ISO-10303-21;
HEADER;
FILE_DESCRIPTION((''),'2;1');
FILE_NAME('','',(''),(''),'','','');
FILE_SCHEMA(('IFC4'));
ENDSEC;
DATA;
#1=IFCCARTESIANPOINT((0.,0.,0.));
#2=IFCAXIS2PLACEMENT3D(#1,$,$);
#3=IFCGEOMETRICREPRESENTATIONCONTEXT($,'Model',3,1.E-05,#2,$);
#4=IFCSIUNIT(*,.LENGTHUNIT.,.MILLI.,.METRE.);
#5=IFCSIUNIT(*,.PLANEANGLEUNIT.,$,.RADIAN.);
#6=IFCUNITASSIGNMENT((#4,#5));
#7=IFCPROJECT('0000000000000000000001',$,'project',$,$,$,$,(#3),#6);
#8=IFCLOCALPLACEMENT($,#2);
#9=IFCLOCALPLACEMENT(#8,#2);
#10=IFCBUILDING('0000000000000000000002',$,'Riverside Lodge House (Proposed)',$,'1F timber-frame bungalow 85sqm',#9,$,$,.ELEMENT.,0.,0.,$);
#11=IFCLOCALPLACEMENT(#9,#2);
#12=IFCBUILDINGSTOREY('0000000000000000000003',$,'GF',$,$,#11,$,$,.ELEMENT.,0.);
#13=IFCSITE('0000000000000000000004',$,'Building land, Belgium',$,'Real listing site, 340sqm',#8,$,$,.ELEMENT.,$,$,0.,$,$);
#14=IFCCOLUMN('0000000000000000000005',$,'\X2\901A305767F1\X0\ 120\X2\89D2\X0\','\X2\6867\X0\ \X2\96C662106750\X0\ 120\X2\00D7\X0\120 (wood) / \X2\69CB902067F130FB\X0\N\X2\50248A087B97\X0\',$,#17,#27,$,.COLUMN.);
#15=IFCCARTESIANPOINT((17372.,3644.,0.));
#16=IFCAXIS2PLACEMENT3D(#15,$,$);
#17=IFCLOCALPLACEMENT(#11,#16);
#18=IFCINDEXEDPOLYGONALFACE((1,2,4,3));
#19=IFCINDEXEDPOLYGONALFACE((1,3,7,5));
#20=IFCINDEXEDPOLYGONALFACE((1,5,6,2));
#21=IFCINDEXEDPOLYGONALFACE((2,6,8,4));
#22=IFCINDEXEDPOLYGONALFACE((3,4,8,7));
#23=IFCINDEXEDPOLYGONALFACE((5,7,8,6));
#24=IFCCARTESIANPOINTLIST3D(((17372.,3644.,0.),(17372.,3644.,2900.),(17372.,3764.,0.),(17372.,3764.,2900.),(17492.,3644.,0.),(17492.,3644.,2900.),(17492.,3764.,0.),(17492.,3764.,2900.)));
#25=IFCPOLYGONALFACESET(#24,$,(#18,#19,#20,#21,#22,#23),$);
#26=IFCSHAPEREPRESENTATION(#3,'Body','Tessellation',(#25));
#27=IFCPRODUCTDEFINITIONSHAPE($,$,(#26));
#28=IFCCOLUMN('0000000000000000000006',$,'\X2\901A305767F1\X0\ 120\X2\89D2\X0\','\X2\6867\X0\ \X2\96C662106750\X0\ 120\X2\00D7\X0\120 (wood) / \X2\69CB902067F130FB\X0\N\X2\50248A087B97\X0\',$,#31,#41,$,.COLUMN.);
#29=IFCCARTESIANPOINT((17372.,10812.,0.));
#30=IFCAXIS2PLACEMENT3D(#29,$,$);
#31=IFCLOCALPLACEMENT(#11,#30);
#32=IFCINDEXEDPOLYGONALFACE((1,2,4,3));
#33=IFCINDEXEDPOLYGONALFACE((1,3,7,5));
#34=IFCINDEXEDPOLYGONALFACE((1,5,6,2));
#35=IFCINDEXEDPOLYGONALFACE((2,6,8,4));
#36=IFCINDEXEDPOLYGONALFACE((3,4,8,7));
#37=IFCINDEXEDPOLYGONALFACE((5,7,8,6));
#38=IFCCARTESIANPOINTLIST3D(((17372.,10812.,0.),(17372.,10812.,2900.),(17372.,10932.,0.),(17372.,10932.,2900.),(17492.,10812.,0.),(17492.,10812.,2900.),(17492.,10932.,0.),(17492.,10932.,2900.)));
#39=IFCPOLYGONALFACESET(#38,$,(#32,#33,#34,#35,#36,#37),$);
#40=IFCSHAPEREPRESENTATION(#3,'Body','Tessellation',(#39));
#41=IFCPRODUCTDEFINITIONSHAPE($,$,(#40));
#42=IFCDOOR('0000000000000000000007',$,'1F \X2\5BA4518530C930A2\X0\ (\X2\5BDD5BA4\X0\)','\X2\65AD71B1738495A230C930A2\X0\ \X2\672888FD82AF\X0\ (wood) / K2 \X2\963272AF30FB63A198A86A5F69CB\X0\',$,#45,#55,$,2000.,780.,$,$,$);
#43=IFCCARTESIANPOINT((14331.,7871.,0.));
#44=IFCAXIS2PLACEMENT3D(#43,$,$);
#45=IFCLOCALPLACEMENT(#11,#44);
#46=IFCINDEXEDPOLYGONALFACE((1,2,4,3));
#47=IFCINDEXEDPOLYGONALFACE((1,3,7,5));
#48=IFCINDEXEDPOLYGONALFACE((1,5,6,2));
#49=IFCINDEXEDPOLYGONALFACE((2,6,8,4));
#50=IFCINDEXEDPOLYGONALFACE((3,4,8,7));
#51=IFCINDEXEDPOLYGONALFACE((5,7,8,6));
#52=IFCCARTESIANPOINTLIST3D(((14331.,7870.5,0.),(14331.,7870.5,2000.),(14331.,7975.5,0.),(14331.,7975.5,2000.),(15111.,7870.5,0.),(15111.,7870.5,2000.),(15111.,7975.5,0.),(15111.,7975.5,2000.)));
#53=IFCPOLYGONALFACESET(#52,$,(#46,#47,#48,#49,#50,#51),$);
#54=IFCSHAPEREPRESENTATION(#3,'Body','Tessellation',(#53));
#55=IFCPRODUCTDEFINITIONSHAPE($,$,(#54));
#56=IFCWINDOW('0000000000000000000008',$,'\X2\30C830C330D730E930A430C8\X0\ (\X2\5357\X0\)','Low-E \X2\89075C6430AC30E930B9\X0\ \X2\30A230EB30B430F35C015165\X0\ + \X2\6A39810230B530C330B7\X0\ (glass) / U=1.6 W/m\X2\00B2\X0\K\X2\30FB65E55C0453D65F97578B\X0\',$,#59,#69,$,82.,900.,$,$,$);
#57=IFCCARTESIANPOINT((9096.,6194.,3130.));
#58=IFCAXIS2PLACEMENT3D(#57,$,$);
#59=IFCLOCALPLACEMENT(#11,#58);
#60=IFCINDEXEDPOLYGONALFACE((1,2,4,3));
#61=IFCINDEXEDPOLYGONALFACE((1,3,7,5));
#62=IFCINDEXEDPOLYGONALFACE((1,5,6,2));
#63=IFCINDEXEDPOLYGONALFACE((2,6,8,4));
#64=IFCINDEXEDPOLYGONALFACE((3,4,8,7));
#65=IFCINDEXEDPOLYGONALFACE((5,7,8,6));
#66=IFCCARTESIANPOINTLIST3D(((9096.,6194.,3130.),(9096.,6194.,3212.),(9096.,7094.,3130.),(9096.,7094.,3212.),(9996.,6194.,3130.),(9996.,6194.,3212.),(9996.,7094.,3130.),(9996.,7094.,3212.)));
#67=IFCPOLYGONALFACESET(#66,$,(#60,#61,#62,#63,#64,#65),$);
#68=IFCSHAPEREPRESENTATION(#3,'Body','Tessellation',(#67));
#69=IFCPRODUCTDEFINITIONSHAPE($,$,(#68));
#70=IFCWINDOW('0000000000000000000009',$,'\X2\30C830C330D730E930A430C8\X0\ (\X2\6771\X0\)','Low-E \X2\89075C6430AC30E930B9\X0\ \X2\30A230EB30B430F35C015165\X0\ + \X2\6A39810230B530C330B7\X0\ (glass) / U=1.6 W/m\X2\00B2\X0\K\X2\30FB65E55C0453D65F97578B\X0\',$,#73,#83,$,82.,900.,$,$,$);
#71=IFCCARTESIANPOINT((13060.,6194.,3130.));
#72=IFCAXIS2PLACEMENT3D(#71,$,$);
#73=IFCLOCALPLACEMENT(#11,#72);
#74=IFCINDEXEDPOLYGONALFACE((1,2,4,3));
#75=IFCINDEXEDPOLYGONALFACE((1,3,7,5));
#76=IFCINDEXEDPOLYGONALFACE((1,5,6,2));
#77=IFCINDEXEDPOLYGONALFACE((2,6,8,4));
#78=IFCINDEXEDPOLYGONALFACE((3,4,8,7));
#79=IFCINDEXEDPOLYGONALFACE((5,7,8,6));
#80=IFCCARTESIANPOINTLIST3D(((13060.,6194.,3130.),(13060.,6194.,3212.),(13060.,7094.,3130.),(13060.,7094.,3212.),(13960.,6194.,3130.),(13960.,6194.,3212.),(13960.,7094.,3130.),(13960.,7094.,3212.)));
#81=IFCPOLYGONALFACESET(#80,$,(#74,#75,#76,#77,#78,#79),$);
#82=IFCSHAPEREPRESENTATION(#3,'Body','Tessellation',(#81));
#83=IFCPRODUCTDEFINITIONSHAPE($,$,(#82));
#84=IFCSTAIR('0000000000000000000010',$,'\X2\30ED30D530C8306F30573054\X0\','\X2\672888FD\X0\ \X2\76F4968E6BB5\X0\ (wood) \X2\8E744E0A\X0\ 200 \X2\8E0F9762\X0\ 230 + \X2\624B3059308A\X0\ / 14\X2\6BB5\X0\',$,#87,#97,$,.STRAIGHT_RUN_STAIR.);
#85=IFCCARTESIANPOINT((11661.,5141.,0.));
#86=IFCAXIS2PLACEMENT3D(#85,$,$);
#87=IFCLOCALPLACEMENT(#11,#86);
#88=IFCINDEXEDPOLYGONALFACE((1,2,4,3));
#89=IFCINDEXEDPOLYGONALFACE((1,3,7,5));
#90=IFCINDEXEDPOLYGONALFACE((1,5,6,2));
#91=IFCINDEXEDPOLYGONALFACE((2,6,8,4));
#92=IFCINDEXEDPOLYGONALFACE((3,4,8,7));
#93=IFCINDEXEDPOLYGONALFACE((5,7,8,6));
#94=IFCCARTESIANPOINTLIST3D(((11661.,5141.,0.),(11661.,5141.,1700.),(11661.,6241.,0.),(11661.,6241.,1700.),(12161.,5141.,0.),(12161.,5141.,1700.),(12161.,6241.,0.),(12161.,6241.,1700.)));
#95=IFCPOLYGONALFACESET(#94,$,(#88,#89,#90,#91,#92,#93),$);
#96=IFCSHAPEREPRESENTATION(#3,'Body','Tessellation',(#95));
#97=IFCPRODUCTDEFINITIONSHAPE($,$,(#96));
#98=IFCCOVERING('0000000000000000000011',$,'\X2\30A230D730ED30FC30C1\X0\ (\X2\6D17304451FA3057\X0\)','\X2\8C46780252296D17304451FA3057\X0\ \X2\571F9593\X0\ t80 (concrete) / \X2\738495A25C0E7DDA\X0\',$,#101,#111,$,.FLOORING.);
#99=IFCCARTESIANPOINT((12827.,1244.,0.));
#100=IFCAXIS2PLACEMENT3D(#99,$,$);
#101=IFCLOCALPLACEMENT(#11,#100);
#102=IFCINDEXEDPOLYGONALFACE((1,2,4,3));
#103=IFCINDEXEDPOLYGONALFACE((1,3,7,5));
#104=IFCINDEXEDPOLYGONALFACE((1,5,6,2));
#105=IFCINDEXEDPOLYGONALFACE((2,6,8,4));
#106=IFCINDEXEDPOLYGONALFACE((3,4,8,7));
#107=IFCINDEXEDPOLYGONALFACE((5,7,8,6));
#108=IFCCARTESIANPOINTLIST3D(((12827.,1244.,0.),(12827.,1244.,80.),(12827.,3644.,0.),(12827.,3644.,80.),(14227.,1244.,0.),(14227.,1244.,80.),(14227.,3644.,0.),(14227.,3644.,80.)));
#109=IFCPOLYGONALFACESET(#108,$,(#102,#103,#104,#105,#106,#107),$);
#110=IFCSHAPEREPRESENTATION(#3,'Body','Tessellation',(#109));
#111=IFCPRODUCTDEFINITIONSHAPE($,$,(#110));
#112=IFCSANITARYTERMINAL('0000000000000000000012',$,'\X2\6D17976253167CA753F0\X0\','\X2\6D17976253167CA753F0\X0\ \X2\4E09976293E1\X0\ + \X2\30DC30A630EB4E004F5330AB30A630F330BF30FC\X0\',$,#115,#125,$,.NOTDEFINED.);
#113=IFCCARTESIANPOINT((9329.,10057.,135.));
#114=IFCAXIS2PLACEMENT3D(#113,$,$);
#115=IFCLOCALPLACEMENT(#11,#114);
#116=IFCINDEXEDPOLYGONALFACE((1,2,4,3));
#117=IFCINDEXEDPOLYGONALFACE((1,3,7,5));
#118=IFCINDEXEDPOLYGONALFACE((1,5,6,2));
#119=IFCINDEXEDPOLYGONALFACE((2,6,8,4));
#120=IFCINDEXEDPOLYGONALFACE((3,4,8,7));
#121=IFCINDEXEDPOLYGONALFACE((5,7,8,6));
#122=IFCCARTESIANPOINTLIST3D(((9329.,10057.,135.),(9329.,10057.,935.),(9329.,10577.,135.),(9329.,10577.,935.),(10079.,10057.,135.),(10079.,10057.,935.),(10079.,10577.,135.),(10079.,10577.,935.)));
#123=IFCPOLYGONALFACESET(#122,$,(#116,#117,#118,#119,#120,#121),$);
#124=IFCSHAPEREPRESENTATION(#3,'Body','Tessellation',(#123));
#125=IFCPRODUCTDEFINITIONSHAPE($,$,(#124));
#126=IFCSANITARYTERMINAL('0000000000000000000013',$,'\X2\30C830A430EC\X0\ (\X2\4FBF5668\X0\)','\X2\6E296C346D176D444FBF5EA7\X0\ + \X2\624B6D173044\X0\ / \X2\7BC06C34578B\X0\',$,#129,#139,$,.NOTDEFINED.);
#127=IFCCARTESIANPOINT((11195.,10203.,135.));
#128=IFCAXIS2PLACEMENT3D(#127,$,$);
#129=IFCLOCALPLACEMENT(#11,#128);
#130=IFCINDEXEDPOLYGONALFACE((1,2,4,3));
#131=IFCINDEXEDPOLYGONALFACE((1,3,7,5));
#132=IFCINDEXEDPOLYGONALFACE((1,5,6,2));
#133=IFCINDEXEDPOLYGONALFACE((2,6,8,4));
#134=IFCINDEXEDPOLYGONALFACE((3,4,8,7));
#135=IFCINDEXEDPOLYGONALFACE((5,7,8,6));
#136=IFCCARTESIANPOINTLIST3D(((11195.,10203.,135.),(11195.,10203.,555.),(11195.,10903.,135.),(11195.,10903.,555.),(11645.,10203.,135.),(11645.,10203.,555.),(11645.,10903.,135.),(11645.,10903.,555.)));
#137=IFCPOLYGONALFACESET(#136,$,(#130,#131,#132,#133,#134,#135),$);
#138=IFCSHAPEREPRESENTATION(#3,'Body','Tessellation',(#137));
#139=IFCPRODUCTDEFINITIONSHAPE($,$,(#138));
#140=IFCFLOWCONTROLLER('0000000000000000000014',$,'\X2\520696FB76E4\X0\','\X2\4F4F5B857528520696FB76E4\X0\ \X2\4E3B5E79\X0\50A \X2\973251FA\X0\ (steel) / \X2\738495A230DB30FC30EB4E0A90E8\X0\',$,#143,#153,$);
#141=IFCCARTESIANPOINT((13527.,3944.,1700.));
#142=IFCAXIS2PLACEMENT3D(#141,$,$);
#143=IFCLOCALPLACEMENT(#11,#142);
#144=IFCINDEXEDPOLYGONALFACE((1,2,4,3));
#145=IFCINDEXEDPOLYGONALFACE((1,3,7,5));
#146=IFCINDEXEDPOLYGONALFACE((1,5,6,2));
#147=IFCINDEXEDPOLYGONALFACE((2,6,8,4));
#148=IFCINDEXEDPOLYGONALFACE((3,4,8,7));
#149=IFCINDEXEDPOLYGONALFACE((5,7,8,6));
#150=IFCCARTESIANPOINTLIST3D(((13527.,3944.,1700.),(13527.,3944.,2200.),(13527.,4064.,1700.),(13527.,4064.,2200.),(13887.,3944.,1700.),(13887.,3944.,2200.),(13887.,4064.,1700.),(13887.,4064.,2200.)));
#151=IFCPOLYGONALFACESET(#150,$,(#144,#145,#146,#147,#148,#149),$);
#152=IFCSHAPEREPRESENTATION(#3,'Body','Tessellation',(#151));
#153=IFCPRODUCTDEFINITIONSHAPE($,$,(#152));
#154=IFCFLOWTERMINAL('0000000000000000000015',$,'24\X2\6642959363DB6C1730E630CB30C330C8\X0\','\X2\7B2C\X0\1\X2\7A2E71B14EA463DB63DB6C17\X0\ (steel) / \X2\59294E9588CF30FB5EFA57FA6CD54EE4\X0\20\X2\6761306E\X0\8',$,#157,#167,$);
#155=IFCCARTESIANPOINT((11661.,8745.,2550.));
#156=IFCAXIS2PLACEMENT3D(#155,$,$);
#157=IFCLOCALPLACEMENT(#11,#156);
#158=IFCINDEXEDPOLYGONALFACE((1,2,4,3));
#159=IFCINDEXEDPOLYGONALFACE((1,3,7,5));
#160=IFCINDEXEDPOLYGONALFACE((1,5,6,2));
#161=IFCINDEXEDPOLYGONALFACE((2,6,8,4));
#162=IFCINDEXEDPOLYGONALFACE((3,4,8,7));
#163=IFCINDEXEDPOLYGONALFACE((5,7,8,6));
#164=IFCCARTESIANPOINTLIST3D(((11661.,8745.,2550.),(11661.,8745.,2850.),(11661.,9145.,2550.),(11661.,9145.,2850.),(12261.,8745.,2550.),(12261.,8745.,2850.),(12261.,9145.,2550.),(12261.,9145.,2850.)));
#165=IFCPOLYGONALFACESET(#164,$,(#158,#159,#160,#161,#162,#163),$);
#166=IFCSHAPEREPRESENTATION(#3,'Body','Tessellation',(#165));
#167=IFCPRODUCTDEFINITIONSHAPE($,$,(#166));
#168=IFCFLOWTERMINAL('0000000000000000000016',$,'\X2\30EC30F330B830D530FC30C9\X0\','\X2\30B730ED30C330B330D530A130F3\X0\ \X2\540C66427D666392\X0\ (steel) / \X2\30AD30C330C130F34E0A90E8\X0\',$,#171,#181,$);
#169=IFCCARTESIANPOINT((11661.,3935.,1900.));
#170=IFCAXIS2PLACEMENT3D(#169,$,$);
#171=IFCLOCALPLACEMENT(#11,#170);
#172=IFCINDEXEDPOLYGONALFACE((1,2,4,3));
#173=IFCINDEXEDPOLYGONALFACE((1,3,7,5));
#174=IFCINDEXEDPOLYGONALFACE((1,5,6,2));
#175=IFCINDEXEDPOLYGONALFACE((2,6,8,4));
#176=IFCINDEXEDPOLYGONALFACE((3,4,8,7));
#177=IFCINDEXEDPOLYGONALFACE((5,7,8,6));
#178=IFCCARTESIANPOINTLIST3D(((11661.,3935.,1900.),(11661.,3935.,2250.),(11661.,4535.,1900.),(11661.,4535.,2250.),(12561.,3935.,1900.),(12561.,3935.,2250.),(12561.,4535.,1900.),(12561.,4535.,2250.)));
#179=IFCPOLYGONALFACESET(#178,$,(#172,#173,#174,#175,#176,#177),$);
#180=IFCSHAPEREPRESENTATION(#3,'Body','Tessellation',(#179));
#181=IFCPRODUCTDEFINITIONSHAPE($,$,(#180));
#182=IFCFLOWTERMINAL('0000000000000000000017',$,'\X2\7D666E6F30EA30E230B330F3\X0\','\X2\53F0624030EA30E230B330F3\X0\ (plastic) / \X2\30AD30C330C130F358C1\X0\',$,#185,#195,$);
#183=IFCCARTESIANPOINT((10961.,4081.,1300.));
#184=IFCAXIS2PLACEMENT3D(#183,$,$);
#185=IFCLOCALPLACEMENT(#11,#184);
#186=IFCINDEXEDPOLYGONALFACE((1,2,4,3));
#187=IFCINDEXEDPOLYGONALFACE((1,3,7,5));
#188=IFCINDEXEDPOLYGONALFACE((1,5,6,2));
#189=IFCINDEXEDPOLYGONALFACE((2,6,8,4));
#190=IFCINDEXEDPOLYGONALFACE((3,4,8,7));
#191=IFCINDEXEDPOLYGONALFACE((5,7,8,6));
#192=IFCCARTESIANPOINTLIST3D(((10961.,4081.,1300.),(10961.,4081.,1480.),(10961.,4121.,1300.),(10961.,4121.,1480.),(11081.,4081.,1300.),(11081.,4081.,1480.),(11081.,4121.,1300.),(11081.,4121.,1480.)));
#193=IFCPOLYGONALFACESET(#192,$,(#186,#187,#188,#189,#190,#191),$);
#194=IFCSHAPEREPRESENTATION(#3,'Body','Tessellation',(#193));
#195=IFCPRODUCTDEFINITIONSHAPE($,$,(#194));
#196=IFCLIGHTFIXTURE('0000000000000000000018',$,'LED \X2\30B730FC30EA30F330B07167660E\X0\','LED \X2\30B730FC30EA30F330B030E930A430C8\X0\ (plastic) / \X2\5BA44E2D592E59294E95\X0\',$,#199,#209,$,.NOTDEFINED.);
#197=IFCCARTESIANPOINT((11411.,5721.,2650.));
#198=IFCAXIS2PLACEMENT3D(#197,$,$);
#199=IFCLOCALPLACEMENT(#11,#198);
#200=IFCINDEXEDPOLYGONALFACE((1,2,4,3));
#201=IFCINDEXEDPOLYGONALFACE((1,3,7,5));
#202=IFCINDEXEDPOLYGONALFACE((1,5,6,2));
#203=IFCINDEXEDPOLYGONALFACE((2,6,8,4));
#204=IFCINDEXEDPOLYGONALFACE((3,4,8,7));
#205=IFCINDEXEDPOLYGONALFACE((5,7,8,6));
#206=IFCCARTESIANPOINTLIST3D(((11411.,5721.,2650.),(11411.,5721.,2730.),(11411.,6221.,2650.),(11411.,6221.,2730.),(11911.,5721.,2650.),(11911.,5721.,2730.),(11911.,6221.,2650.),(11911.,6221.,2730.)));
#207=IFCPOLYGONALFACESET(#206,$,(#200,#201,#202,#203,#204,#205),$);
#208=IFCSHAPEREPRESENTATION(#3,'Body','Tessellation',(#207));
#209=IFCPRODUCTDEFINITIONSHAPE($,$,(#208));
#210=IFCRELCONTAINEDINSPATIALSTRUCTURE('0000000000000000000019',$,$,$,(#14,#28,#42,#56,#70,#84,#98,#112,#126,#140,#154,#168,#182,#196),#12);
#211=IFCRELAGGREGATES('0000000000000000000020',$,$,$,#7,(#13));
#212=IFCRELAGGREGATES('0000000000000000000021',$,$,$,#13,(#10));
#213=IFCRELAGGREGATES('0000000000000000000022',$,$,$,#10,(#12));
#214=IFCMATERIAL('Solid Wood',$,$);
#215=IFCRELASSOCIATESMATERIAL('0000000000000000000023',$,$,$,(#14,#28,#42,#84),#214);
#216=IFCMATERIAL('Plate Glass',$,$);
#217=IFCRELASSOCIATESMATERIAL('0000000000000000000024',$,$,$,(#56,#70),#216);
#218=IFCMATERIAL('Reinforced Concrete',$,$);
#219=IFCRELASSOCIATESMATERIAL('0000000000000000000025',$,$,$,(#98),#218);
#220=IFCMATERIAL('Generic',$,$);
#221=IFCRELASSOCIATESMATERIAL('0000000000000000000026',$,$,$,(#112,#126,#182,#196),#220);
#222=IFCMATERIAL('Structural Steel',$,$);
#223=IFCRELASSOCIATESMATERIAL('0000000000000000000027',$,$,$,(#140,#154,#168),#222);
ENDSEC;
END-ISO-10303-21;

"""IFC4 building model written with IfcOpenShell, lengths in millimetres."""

from ifc_helpers import new_model, si_unit, frame, frame_2d, origin, place, context, project, spatial, rectangle, extrude, material, element, save


model = new_model("IFC4")

# Units and contexts
model_context = context("Model", 3, precision=1e-05, world=origin())
ifc_project = project(units=[si_unit("LENGTHUNIT", "METRE", prefix="MILLI"), si_unit("PLANEANGLEUNIT", "RADIAN")], contexts=[model_context])

# Site, building, storey
site_placement = place(None, origin())
site = spatial("IfcSite", under=ifc_project, at=site_placement, Name="Building land, Belgium", ObjectType="Real listing site, 340sqm", CompositionType="ELEMENT", RefElevation=0.0)
building_placement = place(site_placement, origin())
building = spatial("IfcBuilding", under=site, at=building_placement, Name="Riverside Lodge House (Proposed)", ObjectType="1F timber-frame bungalow 85sqm", CompositionType="ELEMENT", ElevationOfRefHeight=0.0, ElevationOfTerrain=0.0)
storey_placement = place(building_placement, origin())
storey = spatial("IfcBuildingStorey", under=building, at=storey_placement, Name="GF", CompositionType="ELEMENT", Elevation=0.0)

# Columns
ifc_material_1 = material(Name="Solid Wood")
column_1_placement = place(storey_placement, frame((17372.0, 3644.0, 0.0)))
element("IfcColumn", 1, at=column_1_placement, inside=storey, material=ifc_material_1, Name="通し柱 120角", Description="桧 集成材 120×120 (wood) / 構造柱・N値計算", PredefinedType="COLUMN", context=model_context, shape_type="SweptSolid", body=[
    extrude(rectangle(XDim=120.0, YDim=120.0, at=frame_2d((60.0, 60.0))), frame((17372.0, 3644.0, 0.0)), (0.0, 0.0, 1.0), 2900.0),
])
column_2_placement = place(storey_placement, frame((17372.0, 10812.0, 0.0)))
element("IfcColumn", 2, at=column_2_placement, inside=storey, material=ifc_material_1, Name="通し柱 120角", Description="桧 集成材 120×120 (wood) / 構造柱・N値計算", PredefinedType="COLUMN", context=model_context, shape_type="SweptSolid", body=[
    extrude(rectangle(XDim=120.0, YDim=120.0, at=frame_2d((60.0, 60.0))), frame((17372.0, 10812.0, 0.0)), (0.0, 0.0, 1.0), 2900.0),
])

# Shared definitions
ifc_material_2 = material(Name="Plate Glass")

# Door
door_placement = place(storey_placement, frame((14331.0, 7871.0, 0.0)))
element("IfcDoor", 3, at=door_placement, inside=storey, material=ifc_material_1, Name="1F 室内ドア (寝室)", Description="断熱玄関ドア 木製芯 (wood) / K2 防犯・採風機構", OverallHeight=2000.0, OverallWidth=780.0, context=model_context, shape_type="SweptSolid", body=[
    extrude(rectangle(XDim=780.0, YDim=105.0, at=frame_2d((390.0, 52.0))), frame((14331.0, 7871.0, 0.0)), (0.0, 0.0, 1.0), 2000.0),
])

# Windows
window_1_placement = place(storey_placement, frame((9096.0, 6194.0, 3130.0)))
element("IfcWindow", 4, at=window_1_placement, inside=storey, material=ifc_material_2, Name="トップライト (南)", Description="Low-E 複層ガラス アルゴン封入 + 樹脂サッシ (glass) / U=1.6 W/m²K・日射取得型", OverallHeight=82.0, OverallWidth=900.0, context=model_context, shape_type="SweptSolid", body=[
    extrude(rectangle(XDim=900.0, YDim=900.0, at=frame_2d((450.0, 450.0))), frame((9096.0, 6194.0, 3130.0)), (0.0, 0.0, 1.0), 82.0),
])
window_2_placement = place(storey_placement, frame((13060.0, 6194.0, 3130.0)))
element("IfcWindow", 5, at=window_2_placement, inside=storey, material=ifc_material_2, Name="トップライト (東)", Description="Low-E 複層ガラス アルゴン封入 + 樹脂サッシ (glass) / U=1.6 W/m²K・日射取得型", OverallHeight=82.0, OverallWidth=900.0, context=model_context, shape_type="SweptSolid", body=[
    extrude(rectangle(XDim=900.0, YDim=900.0, at=frame_2d((450.0, 450.0))), frame((13060.0, 6194.0, 3130.0)), (0.0, 0.0, 1.0), 82.0),
])

# Stair
stair_placement = place(storey_placement, frame((11661.0, 5141.0, 0.0)))
element("IfcStair", 6, at=stair_placement, inside=storey, material=ifc_material_1, Name="ロフトはしご", Description="木製 直階段 (wood) 蹴上 200 踏面 230 + 手すり / 14段", PredefinedType="STRAIGHT_RUN_STAIR", context=model_context, shape_type="SweptSolid", body=[
    extrude(rectangle(XDim=500.0, YDim=1100.0, at=frame_2d((250.0, 550.0))), frame((11661.0, 5141.0, 0.0)), (0.0, 0.0, 1.0), 1700.0),
])

# Covering
ifc_material_3 = material(Name="Reinforced Concrete")
covering_placement = place(storey_placement, frame((12827.0, 1244.0, 0.0)))
element("IfcCovering", 7, at=covering_placement, inside=storey, material=ifc_material_3, Name="アプローチ (洗い出し)", Description="豆砂利洗い出し 土間 t80 (concrete) / 玄関導線", PredefinedType="FLOORING", context=model_context, shape_type="SweptSolid", body=[
    extrude(rectangle(XDim=1400.0, YDim=2400.0, at=frame_2d((700.0, 1200.0))), frame((12827.0, 1244.0, 0.0)), (0.0, 0.0, 1.0), 80.0),
])

# Sanitary terminals
ifc_material_4 = material(Name="Generic")
sanitary_terminal_1_placement = place(storey_placement, frame((9329.0, 10057.0, 135.0)))
element("IfcSanitaryTerminal", 8, at=sanitary_terminal_1_placement, inside=storey, material=ifc_material_4, Name="洗面化粧台", Description="洗面化粧台 三面鏡 + ボウル一体カウンター", PredefinedType="NOTDEFINED", context=model_context, shape_type="SweptSolid", body=[
    extrude(rectangle(XDim=750.0, YDim=520.0, at=frame_2d((375.0, 260.0))), frame((9329.0, 10057.0, 135.0)), (0.0, 0.0, 1.0), 800.0),
])
sanitary_terminal_2_placement = place(storey_placement, frame((11195.0, 10203.0, 135.0)))
element("IfcSanitaryTerminal", 9, at=sanitary_terminal_2_placement, inside=storey, material=ifc_material_4, Name="トイレ (便器)", Description="温水洗浄便座 + 手洗い / 節水型", PredefinedType="NOTDEFINED", context=model_context, shape_type="SweptSolid", body=[
    extrude(rectangle(XDim=450.0, YDim=700.0, at=frame_2d((225.0, 350.0))), frame((11195.0, 10203.0, 135.0)), (0.0, 0.0, 1.0), 420.0),
])

# Flow controller
ifc_material_5 = material(Name="Structural Steel")
flow_controller_placement = place(storey_placement, frame((13527.0, 3944.0, 1700.0)))
element("IfcFlowController", 10, at=flow_controller_placement, inside=storey, material=ifc_material_5, Name="分電盤", Description="住宅用分電盤 主幹50A 露出 (steel) / 玄関ホール上部", context=model_context, shape_type="SweptSolid", body=[
    extrude(rectangle(XDim=360.0, YDim=120.0, at=frame_2d((180.0, 60.0))), frame((13527.0, 3944.0, 1700.0)), (0.0, 0.0, 1.0), 500.0),
])

# Flow terminals
flow_terminal_1_placement = place(storey_placement, frame((11661.0, 8745.0, 2550.0)))
element("IfcFlowTerminal", 11, at=flow_terminal_1_placement, inside=storey, material=ifc_material_5, Name="24時間換気ユニット", Description="第1種熱交換換気 (steel) / 天井裏・建基法令20条の8", context=model_context, shape_type="SweptSolid", body=[
    extrude(rectangle(XDim=600.0, YDim=400.0, at=frame_2d((300.0, 200.0))), frame((11661.0, 8745.0, 2550.0)), (0.0, 0.0, 1.0), 300.0),
])
flow_terminal_2_placement = place(storey_placement, frame((11661.0, 3935.0, 1900.0)))
element("IfcFlowTerminal", 12, at=flow_terminal_2_placement, inside=storey, material=ifc_material_5, Name="レンジフード", Description="シロッコファン 同時給排 (steel) / キッチン上部", context=model_context, shape_type="SweptSolid", body=[
    extrude(rectangle(XDim=900.0, YDim=600.0, at=frame_2d((450.0, 300.0))), frame((11661.0, 3935.0, 1900.0)), (0.0, 0.0, 1.0), 350.0),
])
flow_terminal_3_placement = place(storey_placement, frame((10961.0, 4081.0, 1300.0)))
element("IfcFlowTerminal", 13, at=flow_terminal_3_placement, inside=storey, material=ifc_material_4, Name="給湯リモコン", Description="台所リモコン (plastic) / キッチン壁", context=model_context, shape_type="SweptSolid", body=[
    extrude(rectangle(XDim=120.0, YDim=40.0, at=frame_2d((60.0, 20.0))), frame((10961.0, 4081.0, 1300.0)), (0.0, 0.0, 1.0), 180.0),
])

# Light fixture
light_fixture_1_placement = place(storey_placement, frame((11411.0, 5721.0, 2650.0)))
element("IfcLightFixture", 14, at=light_fixture_1_placement, inside=storey, material=ifc_material_4, Name="LED シーリング照明", Description="LED シーリングライト (plastic) / 室中央天井", PredefinedType="NOTDEFINED", context=model_context, shape_type="SweptSolid", body=[
    extrude(rectangle(XDim=500.0, YDim=500.0, at=frame_2d((250.0, 250.0))), frame((11411.0, 5721.0, 2650.0)), (0.0, 0.0, 1.0), 80.0),
])

save(model, "model.ifc")
